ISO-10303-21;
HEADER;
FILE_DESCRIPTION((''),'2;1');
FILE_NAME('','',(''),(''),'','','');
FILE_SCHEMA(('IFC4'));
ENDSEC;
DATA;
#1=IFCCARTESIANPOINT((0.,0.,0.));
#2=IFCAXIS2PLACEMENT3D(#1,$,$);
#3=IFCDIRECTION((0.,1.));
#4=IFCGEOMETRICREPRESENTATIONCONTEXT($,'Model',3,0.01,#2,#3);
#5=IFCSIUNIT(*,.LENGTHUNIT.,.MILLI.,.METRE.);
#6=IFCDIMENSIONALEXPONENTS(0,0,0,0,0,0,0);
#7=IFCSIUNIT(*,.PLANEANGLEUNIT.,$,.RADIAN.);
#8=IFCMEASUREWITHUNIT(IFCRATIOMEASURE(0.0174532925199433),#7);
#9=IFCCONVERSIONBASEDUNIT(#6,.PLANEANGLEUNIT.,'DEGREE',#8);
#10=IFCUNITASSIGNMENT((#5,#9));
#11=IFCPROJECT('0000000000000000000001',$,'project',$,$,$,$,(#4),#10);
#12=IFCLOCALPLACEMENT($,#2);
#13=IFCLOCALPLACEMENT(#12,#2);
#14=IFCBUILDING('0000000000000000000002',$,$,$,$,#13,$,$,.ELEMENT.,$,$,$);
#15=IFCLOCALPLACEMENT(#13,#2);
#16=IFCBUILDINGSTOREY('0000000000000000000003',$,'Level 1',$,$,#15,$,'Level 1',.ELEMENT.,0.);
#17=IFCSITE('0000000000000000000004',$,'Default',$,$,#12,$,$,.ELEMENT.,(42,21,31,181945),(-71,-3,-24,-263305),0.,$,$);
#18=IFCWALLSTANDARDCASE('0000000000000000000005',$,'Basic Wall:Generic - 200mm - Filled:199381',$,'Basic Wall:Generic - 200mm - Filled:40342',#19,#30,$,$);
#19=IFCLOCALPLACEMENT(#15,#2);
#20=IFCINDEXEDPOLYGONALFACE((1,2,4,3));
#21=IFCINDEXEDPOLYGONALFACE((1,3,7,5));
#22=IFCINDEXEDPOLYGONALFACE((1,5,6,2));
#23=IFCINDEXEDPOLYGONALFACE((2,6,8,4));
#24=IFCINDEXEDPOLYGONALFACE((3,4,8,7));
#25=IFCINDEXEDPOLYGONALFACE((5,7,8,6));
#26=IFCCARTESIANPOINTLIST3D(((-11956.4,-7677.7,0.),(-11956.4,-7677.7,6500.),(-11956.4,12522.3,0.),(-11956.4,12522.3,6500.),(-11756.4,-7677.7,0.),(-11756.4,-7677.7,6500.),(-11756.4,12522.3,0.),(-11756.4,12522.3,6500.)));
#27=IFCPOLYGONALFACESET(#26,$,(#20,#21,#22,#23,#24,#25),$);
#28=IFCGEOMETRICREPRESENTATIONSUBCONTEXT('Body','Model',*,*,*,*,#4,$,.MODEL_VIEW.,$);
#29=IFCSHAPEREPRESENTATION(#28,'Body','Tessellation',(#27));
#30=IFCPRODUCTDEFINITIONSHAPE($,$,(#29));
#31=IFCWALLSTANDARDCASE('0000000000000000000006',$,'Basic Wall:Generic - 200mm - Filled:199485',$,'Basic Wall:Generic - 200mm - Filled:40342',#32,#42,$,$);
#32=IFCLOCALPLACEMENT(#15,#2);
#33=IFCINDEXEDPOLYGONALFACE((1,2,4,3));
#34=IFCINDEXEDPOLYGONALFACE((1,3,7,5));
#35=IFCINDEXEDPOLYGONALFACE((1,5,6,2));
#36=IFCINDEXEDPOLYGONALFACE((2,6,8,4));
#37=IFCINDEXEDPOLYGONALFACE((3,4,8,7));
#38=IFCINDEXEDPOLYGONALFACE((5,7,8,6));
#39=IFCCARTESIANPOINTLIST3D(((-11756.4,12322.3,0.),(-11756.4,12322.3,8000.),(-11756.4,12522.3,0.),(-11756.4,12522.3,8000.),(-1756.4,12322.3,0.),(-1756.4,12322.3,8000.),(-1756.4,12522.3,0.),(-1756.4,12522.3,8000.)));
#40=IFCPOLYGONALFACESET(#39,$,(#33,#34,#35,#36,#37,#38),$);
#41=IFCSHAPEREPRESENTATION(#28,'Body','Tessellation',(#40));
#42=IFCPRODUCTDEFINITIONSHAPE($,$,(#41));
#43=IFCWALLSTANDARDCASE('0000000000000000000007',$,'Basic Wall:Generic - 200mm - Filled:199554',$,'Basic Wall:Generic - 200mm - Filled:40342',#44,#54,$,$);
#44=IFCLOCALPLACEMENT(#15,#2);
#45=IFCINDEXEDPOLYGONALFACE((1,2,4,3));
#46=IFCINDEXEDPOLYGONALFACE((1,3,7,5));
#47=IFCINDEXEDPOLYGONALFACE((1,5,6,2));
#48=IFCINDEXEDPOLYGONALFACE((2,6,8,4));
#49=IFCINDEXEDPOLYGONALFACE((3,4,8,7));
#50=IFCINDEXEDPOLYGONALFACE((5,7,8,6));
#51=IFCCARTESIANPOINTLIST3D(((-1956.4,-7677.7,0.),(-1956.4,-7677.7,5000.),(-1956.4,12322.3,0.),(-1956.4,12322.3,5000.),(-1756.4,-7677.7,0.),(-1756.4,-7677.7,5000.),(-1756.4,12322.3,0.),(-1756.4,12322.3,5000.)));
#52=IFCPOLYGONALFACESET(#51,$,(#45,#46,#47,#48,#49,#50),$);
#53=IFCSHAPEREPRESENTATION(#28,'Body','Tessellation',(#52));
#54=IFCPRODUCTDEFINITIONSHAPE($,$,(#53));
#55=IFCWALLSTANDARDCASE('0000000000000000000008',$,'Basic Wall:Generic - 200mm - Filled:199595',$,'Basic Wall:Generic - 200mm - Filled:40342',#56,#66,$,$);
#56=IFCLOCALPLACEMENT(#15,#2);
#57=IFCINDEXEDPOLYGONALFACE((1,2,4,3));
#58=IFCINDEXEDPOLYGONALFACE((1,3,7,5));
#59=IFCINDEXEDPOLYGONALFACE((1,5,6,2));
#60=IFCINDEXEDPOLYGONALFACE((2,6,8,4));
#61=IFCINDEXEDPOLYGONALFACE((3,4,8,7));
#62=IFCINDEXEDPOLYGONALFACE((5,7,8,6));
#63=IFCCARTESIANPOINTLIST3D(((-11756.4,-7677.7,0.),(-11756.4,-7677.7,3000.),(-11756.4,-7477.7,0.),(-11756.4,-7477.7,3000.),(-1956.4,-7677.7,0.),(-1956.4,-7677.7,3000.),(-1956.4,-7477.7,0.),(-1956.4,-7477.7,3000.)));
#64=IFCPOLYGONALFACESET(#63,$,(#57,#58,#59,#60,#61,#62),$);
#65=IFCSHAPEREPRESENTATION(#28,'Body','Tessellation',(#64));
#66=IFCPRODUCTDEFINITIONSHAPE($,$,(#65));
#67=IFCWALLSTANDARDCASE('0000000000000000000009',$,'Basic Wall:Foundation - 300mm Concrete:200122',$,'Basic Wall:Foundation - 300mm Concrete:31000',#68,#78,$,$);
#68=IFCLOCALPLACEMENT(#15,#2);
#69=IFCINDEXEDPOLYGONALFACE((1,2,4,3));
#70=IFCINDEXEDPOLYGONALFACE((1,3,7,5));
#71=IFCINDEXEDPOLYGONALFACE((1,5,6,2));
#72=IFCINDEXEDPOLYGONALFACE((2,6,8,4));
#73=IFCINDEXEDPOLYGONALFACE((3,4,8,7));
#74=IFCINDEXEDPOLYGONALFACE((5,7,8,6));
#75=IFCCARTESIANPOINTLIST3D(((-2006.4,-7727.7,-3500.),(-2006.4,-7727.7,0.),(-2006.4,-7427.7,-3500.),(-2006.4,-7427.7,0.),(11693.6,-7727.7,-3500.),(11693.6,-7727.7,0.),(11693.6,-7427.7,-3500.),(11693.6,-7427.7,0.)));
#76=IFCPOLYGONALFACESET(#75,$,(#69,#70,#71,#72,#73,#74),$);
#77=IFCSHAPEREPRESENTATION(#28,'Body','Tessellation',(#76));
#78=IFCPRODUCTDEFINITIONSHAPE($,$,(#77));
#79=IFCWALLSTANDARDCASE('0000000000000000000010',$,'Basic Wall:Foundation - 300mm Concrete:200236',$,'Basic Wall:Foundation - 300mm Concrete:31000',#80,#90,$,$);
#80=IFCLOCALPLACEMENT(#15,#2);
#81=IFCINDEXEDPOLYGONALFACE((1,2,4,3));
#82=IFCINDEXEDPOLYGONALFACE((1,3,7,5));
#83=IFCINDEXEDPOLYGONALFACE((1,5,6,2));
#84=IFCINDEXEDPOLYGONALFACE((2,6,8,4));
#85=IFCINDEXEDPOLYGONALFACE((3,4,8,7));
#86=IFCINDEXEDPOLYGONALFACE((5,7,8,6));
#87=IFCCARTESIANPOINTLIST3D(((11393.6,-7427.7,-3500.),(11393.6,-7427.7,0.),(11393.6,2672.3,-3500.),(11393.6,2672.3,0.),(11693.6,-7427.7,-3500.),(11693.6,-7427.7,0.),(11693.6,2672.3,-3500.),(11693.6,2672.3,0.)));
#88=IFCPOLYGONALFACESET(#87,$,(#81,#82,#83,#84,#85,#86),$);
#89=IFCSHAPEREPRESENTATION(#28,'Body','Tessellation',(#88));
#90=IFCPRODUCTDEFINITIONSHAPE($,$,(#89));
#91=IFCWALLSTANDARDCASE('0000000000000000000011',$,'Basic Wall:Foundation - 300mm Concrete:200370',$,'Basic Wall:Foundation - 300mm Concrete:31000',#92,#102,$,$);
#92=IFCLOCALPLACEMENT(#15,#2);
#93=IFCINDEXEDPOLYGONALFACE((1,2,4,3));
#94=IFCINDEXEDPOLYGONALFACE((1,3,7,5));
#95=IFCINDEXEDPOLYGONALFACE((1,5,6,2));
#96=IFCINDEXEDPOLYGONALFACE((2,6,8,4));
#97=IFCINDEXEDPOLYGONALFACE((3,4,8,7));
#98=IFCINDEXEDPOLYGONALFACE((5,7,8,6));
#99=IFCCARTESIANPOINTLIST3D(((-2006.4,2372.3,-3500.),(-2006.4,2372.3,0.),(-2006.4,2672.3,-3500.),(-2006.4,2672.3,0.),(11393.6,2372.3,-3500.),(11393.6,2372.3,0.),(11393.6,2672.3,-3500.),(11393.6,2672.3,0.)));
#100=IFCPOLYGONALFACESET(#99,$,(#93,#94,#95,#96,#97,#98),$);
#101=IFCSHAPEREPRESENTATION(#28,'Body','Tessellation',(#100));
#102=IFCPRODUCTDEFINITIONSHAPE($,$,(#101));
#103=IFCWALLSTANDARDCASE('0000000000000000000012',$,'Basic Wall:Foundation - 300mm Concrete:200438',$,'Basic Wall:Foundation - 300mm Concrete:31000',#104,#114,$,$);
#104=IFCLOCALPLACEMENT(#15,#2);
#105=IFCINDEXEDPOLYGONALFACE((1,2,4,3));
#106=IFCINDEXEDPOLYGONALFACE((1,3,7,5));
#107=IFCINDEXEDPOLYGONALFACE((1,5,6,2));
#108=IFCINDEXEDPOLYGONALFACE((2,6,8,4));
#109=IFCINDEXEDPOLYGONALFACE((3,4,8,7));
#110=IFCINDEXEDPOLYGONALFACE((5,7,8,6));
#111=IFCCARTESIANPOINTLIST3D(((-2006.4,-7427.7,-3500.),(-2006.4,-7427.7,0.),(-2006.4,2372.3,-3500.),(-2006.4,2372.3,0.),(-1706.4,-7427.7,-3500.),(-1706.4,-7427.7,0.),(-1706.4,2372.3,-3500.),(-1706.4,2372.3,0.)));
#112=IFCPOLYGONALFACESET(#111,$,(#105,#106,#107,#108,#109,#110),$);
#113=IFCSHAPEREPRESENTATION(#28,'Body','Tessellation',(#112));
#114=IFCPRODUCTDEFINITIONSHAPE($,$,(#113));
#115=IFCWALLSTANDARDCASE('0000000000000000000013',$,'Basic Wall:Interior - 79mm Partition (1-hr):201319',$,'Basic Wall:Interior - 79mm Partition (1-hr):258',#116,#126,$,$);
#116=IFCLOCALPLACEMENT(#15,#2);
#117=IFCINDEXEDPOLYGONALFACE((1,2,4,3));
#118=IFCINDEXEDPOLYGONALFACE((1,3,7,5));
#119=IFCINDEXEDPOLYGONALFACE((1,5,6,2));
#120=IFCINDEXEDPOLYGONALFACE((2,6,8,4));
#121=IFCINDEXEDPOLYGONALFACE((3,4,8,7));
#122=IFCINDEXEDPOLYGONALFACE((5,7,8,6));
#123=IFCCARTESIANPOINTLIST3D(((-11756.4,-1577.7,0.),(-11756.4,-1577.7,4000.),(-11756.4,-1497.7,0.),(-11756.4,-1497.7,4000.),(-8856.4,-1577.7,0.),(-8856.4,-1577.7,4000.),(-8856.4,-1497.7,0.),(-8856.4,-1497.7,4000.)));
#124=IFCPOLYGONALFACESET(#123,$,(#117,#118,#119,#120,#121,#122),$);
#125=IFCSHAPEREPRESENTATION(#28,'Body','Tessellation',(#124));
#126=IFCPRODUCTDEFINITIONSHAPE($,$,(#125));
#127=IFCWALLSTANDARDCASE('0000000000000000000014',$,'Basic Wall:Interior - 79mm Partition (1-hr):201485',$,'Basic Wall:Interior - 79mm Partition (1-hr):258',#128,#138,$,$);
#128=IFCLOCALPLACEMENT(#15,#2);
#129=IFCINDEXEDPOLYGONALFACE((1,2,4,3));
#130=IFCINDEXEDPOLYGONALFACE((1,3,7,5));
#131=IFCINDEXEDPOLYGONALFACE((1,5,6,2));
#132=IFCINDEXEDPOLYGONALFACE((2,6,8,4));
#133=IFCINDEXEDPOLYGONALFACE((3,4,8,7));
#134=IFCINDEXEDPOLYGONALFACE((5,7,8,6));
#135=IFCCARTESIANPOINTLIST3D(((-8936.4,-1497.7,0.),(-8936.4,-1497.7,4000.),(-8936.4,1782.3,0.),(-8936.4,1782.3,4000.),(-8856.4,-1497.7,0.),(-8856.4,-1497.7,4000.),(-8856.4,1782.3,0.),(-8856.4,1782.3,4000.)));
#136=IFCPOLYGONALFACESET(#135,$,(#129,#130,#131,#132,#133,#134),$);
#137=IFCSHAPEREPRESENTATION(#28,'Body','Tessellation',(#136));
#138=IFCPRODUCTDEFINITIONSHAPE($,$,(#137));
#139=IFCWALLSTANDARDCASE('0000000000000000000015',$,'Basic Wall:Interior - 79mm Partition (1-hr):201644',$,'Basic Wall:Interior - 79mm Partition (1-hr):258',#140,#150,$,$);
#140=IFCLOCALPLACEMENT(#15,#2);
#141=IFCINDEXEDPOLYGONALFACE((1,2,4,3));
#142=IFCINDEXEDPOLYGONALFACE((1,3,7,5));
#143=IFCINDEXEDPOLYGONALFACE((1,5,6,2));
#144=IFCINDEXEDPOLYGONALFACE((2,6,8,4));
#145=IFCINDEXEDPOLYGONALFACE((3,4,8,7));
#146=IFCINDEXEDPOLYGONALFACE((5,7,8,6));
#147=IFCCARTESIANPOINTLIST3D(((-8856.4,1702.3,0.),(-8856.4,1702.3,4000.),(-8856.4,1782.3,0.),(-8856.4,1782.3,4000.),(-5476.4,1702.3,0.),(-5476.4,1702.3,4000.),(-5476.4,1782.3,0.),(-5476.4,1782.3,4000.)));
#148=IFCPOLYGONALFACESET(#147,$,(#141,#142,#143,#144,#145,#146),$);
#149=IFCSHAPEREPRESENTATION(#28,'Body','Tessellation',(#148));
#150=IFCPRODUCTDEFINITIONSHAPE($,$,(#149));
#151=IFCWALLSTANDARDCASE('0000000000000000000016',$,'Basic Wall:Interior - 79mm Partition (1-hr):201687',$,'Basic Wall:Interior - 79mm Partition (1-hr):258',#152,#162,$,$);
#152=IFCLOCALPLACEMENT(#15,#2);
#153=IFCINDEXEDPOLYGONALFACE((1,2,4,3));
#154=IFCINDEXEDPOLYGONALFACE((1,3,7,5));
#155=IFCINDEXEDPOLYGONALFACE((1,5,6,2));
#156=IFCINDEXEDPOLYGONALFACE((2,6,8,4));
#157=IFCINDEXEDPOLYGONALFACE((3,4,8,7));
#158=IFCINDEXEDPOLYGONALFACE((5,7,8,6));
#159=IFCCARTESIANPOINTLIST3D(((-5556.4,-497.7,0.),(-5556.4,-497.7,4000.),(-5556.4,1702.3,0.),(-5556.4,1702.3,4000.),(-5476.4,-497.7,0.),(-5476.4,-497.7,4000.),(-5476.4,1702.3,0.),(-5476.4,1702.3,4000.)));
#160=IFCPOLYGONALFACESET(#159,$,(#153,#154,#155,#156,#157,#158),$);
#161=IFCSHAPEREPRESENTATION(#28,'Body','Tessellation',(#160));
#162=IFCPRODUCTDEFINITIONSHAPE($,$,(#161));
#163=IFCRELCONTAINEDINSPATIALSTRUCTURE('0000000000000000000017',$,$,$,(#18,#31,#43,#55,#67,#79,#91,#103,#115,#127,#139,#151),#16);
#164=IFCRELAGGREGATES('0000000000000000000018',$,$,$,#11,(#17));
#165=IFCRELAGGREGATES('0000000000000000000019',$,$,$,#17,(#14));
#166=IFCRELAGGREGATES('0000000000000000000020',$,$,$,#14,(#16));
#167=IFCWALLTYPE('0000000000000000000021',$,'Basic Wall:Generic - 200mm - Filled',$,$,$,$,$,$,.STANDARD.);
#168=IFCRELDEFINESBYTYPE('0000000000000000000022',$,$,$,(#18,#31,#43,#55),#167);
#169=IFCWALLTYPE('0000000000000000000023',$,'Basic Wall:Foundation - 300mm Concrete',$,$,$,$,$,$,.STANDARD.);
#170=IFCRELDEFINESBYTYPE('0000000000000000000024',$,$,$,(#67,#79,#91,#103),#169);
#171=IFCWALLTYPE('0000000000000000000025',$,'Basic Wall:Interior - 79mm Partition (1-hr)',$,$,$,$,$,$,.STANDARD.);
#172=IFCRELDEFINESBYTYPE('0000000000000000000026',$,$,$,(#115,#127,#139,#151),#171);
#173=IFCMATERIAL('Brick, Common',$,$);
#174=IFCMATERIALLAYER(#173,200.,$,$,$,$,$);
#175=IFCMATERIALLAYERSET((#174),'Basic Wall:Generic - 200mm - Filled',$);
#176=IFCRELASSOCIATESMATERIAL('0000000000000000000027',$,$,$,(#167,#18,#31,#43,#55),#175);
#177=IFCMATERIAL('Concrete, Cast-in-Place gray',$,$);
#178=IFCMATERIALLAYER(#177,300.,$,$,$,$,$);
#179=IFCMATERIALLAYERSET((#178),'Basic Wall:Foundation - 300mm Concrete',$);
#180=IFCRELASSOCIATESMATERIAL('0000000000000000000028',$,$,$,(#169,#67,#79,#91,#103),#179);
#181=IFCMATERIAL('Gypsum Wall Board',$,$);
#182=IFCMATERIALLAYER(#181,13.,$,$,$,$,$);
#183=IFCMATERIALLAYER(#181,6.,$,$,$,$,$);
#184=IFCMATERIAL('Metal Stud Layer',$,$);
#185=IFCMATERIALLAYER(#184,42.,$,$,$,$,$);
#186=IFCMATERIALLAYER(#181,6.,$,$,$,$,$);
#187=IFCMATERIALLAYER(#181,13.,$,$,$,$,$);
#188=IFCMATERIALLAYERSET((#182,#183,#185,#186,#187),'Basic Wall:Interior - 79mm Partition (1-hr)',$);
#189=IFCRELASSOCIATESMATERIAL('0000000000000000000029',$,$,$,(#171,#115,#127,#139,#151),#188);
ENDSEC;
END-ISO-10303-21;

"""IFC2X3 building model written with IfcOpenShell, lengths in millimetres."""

from ifc_helpers import new_model, entity, si_unit, converted_unit, direction, frame, frame_2d, origin, place, context, subcontext, project, spatial, rectangle, extrude, material, layer, layer_set, layer_usage, type_object, element, save


model = new_model("IFC2X3")

# Units and contexts
model_context = context("Model", 3, precision=0.01, world=origin(), true_north=direction((0.0, 1.0)))
body_context = subcontext(model_context, "Body", "Model", "MODEL_VIEW")
ifc_project = project(units=[si_unit("LENGTHUNIT", "METRE", prefix="MILLI"), converted_unit("PLANEANGLEUNIT", "DEGREE", entity("IfcRatioMeasure", 0.0174532925199433), si_unit("PLANEANGLEUNIT", "RADIAN"), dimensions=[0, 0, 0, 0, 0, 0, 0])], contexts=[model_context])

# Site, building, storey
site_placement = place(None, origin())
site = spatial("IfcSite", under=ifc_project, at=site_placement, Name="Default", CompositionType="ELEMENT", RefLatitude=(42, 21, 31, 181945), RefLongitude=(-71, -3, -24, -263305), RefElevation=0.0)
building_placement = place(site_placement, origin())
building = spatial("IfcBuilding", under=site, at=building_placement, CompositionType="ELEMENT")
storey_placement = place(building_placement, origin())
storey = spatial("IfcBuildingStorey", under=building, at=storey_placement, Name="Level 1", LongName="Level 1", CompositionType="ELEMENT", Elevation=0.0)

# Walls
ifc_material_1 = material(Name="Brick, Common")
ifc_layer_1 = layer(ifc_material_1, 200.0)
ifc_layer_set_1 = layer_set([ifc_layer_1], Name="Basic Wall:Generic - 200mm - Filled")
ifc_layer_usage_1 = layer_usage(ifc_layer_set_1, "AXIS2", "NEGATIVE", 100.0)
wall_type_1 = type_object("IfcWallType", Name="Basic Wall:Generic - 200mm - Filled", PredefinedType="STANDARD", material=ifc_layer_set_1)
wall_1_placement = place(storey_placement, frame((-11856.4, -7677.7, 0.0), z_axis=(0.0, 0.0, 1.0), x_axis=(0.0, 1.0, 0.0)))
element("IfcWallStandardCase", 1, at=wall_1_placement, inside=storey, type_object=wall_type_1, material=ifc_layer_usage_1, Name="Basic Wall:Generic - 200mm - Filled:199381", ObjectType="Basic Wall:Generic - 200mm - Filled:40342", context=body_context, shape_type="SweptSolid", body=[
    extrude(rectangle(XDim=20200.0, YDim=200.0, at=frame_2d((10100.0, 0.0), x_axis=(-1.0, 0.0))), origin(), (0.0, 0.0, 1.0), 6500.0),
])
ifc_layer_usage_2 = layer_usage(ifc_layer_set_1, "AXIS2", "NEGATIVE", 100.0)
wall_2_placement = place(storey_placement, frame((-11756.4, 12422.3, 0.0)))
element("IfcWallStandardCase", 2, at=wall_2_placement, inside=storey, type_object=wall_type_1, material=ifc_layer_usage_2, Name="Basic Wall:Generic - 200mm - Filled:199485", ObjectType="Basic Wall:Generic - 200mm - Filled:40342", context=body_context, shape_type="SweptSolid", body=[
    extrude(rectangle(XDim=10000.0, YDim=200.0, at=frame_2d((5000.0, 0.0), x_axis=(-1.0, 0.0))), origin(), (0.0, 0.0, 1.0), 8000.0),
])
ifc_layer_usage_3 = layer_usage(ifc_layer_set_1, "AXIS2", "NEGATIVE", 100.0)
wall_3_placement = place(storey_placement, frame((-1856.4, 12322.3, 0.0), z_axis=(0.0, 0.0, 1.0), x_axis=(0.0, -1.0, 0.0)))
element("IfcWallStandardCase", 3, at=wall_3_placement, inside=storey, type_object=wall_type_1, material=ifc_layer_usage_3, Name="Basic Wall:Generic - 200mm - Filled:199554", ObjectType="Basic Wall:Generic - 200mm - Filled:40342", context=body_context, shape_type="SweptSolid", body=[
    extrude(rectangle(XDim=20000.0, YDim=200.0, at=frame_2d((10000.0, 0.0), x_axis=(-1.0, 0.0))), origin(), (0.0, 0.0, 1.0), 5000.0),
])
ifc_layer_usage_4 = layer_usage(ifc_layer_set_1, "AXIS2", "NEGATIVE", 100.0)
wall_4_placement = place(storey_placement, frame((-1956.4, -7577.7, 0.0), z_axis=(0.0, 0.0, 1.0), x_axis=(-1.0, 0.0, 0.0)))
element("IfcWallStandardCase", 4, at=wall_4_placement, inside=storey, type_object=wall_type_1, material=ifc_layer_usage_4, Name="Basic Wall:Generic - 200mm - Filled:199595", ObjectType="Basic Wall:Generic - 200mm - Filled:40342", context=body_context, shape_type="SweptSolid", body=[
    extrude(rectangle(XDim=9800.0, YDim=200.0, at=frame_2d((4900.0, 0.0), x_axis=(-1.0, 0.0))), origin(), (0.0, 0.0, 1.0), 3000.0),
])
ifc_material_2 = material(Name="Concrete, Cast-in-Place gray")
ifc_layer_2 = layer(ifc_material_2, 300.0)
ifc_layer_set_2 = layer_set([ifc_layer_2], Name="Basic Wall:Foundation - 300mm Concrete")
ifc_layer_usage_5 = layer_usage(ifc_layer_set_2, "AXIS2", "NEGATIVE", 150.0)
wall_type_2 = type_object("IfcWallType", Name="Basic Wall:Foundation - 300mm Concrete", PredefinedType="STANDARD", material=ifc_layer_set_2)
wall_5_placement = place(storey_placement, frame((-2006.4, -7577.7, -3500.0)))
element("IfcWallStandardCase", 5, at=wall_5_placement, inside=storey, type_object=wall_type_2, material=ifc_layer_usage_5, Name="Basic Wall:Foundation - 300mm Concrete:200122", ObjectType="Basic Wall:Foundation - 300mm Concrete:31000", context=body_context, shape_type="SweptSolid", body=[
    extrude(rectangle(XDim=13700.0, YDim=300.0, at=frame_2d((6850.0, 0.0), x_axis=(-1.0, 0.0))), origin(), (0.0, 0.0, 1.0), 3500.0),
])
ifc_layer_usage_6 = layer_usage(ifc_layer_set_2, "AXIS2", "NEGATIVE", 150.0)
wall_6_placement = place(storey_placement, frame((11543.6, -7427.7, -3500.0), z_axis=(0.0, 0.0, 1.0), x_axis=(0.0, 1.0, 0.0)))
element("IfcWallStandardCase", 6, at=wall_6_placement, inside=storey, type_object=wall_type_2, material=ifc_layer_usage_6, Name="Basic Wall:Foundation - 300mm Concrete:200236", ObjectType="Basic Wall:Foundation - 300mm Concrete:31000", context=body_context, shape_type="SweptSolid", body=[
    extrude(rectangle(XDim=10100.0, YDim=300.0, at=frame_2d((5050.0, 0.0), x_axis=(-1.0, 0.0))), origin(), (0.0, 0.0, 1.0), 3500.0),
])
ifc_layer_usage_7 = layer_usage(ifc_layer_set_2, "AXIS2", "NEGATIVE", 150.0)
wall_7_placement = place(storey_placement, frame((11393.6, 2522.3, -3500.0), z_axis=(0.0, 0.0, 1.0), x_axis=(-1.0, 0.0, 0.0)))
element("IfcWallStandardCase", 7, at=wall_7_placement, inside=storey, type_object=wall_type_2, material=ifc_layer_usage_7, Name="Basic Wall:Foundation - 300mm Concrete:200370", ObjectType="Basic Wall:Foundation - 300mm Concrete:31000", context=body_context, shape_type="SweptSolid", body=[
    extrude(rectangle(XDim=13400.0, YDim=300.0, at=frame_2d((6700.0, 0.0), x_axis=(-1.0, 0.0))), origin(), (0.0, 0.0, 1.0), 3500.0),
])
ifc_layer_usage_8 = layer_usage(ifc_layer_set_2, "AXIS2", "NEGATIVE", 150.0)
wall_8_placement = place(storey_placement, frame((-1856.4, 2372.3, -3500.0), z_axis=(0.0, 0.0, 1.0), x_axis=(0.0, -1.0, 0.0)))
element("IfcWallStandardCase", 8, at=wall_8_placement, inside=storey, type_object=wall_type_2, material=ifc_layer_usage_8, Name="Basic Wall:Foundation - 300mm Concrete:200438", ObjectType="Basic Wall:Foundation - 300mm Concrete:31000", context=body_context, shape_type="SweptSolid", body=[
    extrude(rectangle(XDim=9800.0, YDim=300.0, at=frame_2d((4900.0, 0.0), x_axis=(-1.0, 0.0))), origin(), (0.0, 0.0, 1.0), 3500.0),
])
ifc_material_3 = material(Name="Gypsum Wall Board")
ifc_layer_3 = layer(ifc_material_3, 13.0)
ifc_layer_4 = layer(ifc_material_3, 6.0)
ifc_material_4 = material(Name="Metal Stud Layer")
ifc_layer_5 = layer(ifc_material_4, 42.0)
ifc_layer_6 = layer(ifc_material_3, 6.0)
ifc_layer_7 = layer(ifc_material_3, 13.0)
ifc_layer_set_3 = layer_set([ifc_layer_3, ifc_layer_4, ifc_layer_5, ifc_layer_6, ifc_layer_7], Name="Basic Wall:Interior - 79mm Partition (1-hr)")
ifc_layer_usage_9 = layer_usage(ifc_layer_set_3, "AXIS2", "NEGATIVE", 40.0)
wall_type_3 = type_object("IfcWallType", Name="Basic Wall:Interior - 79mm Partition (1-hr)", PredefinedType="STANDARD", material=ifc_layer_set_3)
wall_9_placement = place(storey_placement, frame((-11756.4, -1537.7, 0.0)))
element("IfcWallStandardCase", 9, at=wall_9_placement, inside=storey, type_object=wall_type_3, material=ifc_layer_usage_9, Name="Basic Wall:Interior - 79mm Partition (1-hr):201319", ObjectType="Basic Wall:Interior - 79mm Partition (1-hr):258", context=body_context, shape_type="SweptSolid", body=[
    extrude(rectangle(XDim=2900.0, YDim=80.0, at=frame_2d((1450.0, 0.0), x_axis=(-1.0, 0.0))), origin(), (0.0, 0.0, 1.0), 4000.0),
])
ifc_layer_usage_10 = layer_usage(ifc_layer_set_3, "AXIS2", "NEGATIVE", 40.0)
wall_10_placement = place(storey_placement, frame((-8896.4, -1497.7, 0.0), z_axis=(0.0, 0.0, 1.0), x_axis=(0.0, 1.0, 0.0)))
element("IfcWallStandardCase", 10, at=wall_10_placement, inside=storey, type_object=wall_type_3, material=ifc_layer_usage_10, Name="Basic Wall:Interior - 79mm Partition (1-hr):201485", ObjectType="Basic Wall:Interior - 79mm Partition (1-hr):258", context=body_context, shape_type="SweptSolid", body=[
    extrude(rectangle(XDim=3280.0, YDim=80.0, at=frame_2d((1640.0, 0.0), x_axis=(-1.0, 0.0))), origin(), (0.0, 0.0, 1.0), 4000.0),
])
ifc_layer_usage_11 = layer_usage(ifc_layer_set_3, "AXIS2", "NEGATIVE", 40.0)
wall_11_placement = place(storey_placement, frame((-8856.4, 1742.3, 0.0)))
element("IfcWallStandardCase", 11, at=wall_11_placement, inside=storey, type_object=wall_type_3, material=ifc_layer_usage_11, Name="Basic Wall:Interior - 79mm Partition (1-hr):201644", ObjectType="Basic Wall:Interior - 79mm Partition (1-hr):258", context=body_context, shape_type="SweptSolid", body=[
    extrude(rectangle(XDim=3380.0, YDim=80.0, at=frame_2d((1690.0, 0.0), x_axis=(-1.0, 0.0))), origin(), (0.0, 0.0, 1.0), 4000.0),
])
ifc_layer_usage_12 = layer_usage(ifc_layer_set_3, "AXIS2", "NEGATIVE", 40.0)
wall_12_placement = place(storey_placement, frame((-5516.4, 1702.3, 0.0), z_axis=(0.0, 0.0, 1.0), x_axis=(0.0, -1.0, 0.0)))
element("IfcWallStandardCase", 12, at=wall_12_placement, inside=storey, type_object=wall_type_3, material=ifc_layer_usage_12, Name="Basic Wall:Interior - 79mm Partition (1-hr):201687", ObjectType="Basic Wall:Interior - 79mm Partition (1-hr):258", context=body_context, shape_type="SweptSolid", body=[
    extrude(rectangle(XDim=2200.0, YDim=80.0, at=frame_2d((1100.0, 0.0), x_axis=(-1.0, 0.0))), origin(), (0.0, 0.0, 1.0), 4000.0),
])

save(model, "model.ifc")
